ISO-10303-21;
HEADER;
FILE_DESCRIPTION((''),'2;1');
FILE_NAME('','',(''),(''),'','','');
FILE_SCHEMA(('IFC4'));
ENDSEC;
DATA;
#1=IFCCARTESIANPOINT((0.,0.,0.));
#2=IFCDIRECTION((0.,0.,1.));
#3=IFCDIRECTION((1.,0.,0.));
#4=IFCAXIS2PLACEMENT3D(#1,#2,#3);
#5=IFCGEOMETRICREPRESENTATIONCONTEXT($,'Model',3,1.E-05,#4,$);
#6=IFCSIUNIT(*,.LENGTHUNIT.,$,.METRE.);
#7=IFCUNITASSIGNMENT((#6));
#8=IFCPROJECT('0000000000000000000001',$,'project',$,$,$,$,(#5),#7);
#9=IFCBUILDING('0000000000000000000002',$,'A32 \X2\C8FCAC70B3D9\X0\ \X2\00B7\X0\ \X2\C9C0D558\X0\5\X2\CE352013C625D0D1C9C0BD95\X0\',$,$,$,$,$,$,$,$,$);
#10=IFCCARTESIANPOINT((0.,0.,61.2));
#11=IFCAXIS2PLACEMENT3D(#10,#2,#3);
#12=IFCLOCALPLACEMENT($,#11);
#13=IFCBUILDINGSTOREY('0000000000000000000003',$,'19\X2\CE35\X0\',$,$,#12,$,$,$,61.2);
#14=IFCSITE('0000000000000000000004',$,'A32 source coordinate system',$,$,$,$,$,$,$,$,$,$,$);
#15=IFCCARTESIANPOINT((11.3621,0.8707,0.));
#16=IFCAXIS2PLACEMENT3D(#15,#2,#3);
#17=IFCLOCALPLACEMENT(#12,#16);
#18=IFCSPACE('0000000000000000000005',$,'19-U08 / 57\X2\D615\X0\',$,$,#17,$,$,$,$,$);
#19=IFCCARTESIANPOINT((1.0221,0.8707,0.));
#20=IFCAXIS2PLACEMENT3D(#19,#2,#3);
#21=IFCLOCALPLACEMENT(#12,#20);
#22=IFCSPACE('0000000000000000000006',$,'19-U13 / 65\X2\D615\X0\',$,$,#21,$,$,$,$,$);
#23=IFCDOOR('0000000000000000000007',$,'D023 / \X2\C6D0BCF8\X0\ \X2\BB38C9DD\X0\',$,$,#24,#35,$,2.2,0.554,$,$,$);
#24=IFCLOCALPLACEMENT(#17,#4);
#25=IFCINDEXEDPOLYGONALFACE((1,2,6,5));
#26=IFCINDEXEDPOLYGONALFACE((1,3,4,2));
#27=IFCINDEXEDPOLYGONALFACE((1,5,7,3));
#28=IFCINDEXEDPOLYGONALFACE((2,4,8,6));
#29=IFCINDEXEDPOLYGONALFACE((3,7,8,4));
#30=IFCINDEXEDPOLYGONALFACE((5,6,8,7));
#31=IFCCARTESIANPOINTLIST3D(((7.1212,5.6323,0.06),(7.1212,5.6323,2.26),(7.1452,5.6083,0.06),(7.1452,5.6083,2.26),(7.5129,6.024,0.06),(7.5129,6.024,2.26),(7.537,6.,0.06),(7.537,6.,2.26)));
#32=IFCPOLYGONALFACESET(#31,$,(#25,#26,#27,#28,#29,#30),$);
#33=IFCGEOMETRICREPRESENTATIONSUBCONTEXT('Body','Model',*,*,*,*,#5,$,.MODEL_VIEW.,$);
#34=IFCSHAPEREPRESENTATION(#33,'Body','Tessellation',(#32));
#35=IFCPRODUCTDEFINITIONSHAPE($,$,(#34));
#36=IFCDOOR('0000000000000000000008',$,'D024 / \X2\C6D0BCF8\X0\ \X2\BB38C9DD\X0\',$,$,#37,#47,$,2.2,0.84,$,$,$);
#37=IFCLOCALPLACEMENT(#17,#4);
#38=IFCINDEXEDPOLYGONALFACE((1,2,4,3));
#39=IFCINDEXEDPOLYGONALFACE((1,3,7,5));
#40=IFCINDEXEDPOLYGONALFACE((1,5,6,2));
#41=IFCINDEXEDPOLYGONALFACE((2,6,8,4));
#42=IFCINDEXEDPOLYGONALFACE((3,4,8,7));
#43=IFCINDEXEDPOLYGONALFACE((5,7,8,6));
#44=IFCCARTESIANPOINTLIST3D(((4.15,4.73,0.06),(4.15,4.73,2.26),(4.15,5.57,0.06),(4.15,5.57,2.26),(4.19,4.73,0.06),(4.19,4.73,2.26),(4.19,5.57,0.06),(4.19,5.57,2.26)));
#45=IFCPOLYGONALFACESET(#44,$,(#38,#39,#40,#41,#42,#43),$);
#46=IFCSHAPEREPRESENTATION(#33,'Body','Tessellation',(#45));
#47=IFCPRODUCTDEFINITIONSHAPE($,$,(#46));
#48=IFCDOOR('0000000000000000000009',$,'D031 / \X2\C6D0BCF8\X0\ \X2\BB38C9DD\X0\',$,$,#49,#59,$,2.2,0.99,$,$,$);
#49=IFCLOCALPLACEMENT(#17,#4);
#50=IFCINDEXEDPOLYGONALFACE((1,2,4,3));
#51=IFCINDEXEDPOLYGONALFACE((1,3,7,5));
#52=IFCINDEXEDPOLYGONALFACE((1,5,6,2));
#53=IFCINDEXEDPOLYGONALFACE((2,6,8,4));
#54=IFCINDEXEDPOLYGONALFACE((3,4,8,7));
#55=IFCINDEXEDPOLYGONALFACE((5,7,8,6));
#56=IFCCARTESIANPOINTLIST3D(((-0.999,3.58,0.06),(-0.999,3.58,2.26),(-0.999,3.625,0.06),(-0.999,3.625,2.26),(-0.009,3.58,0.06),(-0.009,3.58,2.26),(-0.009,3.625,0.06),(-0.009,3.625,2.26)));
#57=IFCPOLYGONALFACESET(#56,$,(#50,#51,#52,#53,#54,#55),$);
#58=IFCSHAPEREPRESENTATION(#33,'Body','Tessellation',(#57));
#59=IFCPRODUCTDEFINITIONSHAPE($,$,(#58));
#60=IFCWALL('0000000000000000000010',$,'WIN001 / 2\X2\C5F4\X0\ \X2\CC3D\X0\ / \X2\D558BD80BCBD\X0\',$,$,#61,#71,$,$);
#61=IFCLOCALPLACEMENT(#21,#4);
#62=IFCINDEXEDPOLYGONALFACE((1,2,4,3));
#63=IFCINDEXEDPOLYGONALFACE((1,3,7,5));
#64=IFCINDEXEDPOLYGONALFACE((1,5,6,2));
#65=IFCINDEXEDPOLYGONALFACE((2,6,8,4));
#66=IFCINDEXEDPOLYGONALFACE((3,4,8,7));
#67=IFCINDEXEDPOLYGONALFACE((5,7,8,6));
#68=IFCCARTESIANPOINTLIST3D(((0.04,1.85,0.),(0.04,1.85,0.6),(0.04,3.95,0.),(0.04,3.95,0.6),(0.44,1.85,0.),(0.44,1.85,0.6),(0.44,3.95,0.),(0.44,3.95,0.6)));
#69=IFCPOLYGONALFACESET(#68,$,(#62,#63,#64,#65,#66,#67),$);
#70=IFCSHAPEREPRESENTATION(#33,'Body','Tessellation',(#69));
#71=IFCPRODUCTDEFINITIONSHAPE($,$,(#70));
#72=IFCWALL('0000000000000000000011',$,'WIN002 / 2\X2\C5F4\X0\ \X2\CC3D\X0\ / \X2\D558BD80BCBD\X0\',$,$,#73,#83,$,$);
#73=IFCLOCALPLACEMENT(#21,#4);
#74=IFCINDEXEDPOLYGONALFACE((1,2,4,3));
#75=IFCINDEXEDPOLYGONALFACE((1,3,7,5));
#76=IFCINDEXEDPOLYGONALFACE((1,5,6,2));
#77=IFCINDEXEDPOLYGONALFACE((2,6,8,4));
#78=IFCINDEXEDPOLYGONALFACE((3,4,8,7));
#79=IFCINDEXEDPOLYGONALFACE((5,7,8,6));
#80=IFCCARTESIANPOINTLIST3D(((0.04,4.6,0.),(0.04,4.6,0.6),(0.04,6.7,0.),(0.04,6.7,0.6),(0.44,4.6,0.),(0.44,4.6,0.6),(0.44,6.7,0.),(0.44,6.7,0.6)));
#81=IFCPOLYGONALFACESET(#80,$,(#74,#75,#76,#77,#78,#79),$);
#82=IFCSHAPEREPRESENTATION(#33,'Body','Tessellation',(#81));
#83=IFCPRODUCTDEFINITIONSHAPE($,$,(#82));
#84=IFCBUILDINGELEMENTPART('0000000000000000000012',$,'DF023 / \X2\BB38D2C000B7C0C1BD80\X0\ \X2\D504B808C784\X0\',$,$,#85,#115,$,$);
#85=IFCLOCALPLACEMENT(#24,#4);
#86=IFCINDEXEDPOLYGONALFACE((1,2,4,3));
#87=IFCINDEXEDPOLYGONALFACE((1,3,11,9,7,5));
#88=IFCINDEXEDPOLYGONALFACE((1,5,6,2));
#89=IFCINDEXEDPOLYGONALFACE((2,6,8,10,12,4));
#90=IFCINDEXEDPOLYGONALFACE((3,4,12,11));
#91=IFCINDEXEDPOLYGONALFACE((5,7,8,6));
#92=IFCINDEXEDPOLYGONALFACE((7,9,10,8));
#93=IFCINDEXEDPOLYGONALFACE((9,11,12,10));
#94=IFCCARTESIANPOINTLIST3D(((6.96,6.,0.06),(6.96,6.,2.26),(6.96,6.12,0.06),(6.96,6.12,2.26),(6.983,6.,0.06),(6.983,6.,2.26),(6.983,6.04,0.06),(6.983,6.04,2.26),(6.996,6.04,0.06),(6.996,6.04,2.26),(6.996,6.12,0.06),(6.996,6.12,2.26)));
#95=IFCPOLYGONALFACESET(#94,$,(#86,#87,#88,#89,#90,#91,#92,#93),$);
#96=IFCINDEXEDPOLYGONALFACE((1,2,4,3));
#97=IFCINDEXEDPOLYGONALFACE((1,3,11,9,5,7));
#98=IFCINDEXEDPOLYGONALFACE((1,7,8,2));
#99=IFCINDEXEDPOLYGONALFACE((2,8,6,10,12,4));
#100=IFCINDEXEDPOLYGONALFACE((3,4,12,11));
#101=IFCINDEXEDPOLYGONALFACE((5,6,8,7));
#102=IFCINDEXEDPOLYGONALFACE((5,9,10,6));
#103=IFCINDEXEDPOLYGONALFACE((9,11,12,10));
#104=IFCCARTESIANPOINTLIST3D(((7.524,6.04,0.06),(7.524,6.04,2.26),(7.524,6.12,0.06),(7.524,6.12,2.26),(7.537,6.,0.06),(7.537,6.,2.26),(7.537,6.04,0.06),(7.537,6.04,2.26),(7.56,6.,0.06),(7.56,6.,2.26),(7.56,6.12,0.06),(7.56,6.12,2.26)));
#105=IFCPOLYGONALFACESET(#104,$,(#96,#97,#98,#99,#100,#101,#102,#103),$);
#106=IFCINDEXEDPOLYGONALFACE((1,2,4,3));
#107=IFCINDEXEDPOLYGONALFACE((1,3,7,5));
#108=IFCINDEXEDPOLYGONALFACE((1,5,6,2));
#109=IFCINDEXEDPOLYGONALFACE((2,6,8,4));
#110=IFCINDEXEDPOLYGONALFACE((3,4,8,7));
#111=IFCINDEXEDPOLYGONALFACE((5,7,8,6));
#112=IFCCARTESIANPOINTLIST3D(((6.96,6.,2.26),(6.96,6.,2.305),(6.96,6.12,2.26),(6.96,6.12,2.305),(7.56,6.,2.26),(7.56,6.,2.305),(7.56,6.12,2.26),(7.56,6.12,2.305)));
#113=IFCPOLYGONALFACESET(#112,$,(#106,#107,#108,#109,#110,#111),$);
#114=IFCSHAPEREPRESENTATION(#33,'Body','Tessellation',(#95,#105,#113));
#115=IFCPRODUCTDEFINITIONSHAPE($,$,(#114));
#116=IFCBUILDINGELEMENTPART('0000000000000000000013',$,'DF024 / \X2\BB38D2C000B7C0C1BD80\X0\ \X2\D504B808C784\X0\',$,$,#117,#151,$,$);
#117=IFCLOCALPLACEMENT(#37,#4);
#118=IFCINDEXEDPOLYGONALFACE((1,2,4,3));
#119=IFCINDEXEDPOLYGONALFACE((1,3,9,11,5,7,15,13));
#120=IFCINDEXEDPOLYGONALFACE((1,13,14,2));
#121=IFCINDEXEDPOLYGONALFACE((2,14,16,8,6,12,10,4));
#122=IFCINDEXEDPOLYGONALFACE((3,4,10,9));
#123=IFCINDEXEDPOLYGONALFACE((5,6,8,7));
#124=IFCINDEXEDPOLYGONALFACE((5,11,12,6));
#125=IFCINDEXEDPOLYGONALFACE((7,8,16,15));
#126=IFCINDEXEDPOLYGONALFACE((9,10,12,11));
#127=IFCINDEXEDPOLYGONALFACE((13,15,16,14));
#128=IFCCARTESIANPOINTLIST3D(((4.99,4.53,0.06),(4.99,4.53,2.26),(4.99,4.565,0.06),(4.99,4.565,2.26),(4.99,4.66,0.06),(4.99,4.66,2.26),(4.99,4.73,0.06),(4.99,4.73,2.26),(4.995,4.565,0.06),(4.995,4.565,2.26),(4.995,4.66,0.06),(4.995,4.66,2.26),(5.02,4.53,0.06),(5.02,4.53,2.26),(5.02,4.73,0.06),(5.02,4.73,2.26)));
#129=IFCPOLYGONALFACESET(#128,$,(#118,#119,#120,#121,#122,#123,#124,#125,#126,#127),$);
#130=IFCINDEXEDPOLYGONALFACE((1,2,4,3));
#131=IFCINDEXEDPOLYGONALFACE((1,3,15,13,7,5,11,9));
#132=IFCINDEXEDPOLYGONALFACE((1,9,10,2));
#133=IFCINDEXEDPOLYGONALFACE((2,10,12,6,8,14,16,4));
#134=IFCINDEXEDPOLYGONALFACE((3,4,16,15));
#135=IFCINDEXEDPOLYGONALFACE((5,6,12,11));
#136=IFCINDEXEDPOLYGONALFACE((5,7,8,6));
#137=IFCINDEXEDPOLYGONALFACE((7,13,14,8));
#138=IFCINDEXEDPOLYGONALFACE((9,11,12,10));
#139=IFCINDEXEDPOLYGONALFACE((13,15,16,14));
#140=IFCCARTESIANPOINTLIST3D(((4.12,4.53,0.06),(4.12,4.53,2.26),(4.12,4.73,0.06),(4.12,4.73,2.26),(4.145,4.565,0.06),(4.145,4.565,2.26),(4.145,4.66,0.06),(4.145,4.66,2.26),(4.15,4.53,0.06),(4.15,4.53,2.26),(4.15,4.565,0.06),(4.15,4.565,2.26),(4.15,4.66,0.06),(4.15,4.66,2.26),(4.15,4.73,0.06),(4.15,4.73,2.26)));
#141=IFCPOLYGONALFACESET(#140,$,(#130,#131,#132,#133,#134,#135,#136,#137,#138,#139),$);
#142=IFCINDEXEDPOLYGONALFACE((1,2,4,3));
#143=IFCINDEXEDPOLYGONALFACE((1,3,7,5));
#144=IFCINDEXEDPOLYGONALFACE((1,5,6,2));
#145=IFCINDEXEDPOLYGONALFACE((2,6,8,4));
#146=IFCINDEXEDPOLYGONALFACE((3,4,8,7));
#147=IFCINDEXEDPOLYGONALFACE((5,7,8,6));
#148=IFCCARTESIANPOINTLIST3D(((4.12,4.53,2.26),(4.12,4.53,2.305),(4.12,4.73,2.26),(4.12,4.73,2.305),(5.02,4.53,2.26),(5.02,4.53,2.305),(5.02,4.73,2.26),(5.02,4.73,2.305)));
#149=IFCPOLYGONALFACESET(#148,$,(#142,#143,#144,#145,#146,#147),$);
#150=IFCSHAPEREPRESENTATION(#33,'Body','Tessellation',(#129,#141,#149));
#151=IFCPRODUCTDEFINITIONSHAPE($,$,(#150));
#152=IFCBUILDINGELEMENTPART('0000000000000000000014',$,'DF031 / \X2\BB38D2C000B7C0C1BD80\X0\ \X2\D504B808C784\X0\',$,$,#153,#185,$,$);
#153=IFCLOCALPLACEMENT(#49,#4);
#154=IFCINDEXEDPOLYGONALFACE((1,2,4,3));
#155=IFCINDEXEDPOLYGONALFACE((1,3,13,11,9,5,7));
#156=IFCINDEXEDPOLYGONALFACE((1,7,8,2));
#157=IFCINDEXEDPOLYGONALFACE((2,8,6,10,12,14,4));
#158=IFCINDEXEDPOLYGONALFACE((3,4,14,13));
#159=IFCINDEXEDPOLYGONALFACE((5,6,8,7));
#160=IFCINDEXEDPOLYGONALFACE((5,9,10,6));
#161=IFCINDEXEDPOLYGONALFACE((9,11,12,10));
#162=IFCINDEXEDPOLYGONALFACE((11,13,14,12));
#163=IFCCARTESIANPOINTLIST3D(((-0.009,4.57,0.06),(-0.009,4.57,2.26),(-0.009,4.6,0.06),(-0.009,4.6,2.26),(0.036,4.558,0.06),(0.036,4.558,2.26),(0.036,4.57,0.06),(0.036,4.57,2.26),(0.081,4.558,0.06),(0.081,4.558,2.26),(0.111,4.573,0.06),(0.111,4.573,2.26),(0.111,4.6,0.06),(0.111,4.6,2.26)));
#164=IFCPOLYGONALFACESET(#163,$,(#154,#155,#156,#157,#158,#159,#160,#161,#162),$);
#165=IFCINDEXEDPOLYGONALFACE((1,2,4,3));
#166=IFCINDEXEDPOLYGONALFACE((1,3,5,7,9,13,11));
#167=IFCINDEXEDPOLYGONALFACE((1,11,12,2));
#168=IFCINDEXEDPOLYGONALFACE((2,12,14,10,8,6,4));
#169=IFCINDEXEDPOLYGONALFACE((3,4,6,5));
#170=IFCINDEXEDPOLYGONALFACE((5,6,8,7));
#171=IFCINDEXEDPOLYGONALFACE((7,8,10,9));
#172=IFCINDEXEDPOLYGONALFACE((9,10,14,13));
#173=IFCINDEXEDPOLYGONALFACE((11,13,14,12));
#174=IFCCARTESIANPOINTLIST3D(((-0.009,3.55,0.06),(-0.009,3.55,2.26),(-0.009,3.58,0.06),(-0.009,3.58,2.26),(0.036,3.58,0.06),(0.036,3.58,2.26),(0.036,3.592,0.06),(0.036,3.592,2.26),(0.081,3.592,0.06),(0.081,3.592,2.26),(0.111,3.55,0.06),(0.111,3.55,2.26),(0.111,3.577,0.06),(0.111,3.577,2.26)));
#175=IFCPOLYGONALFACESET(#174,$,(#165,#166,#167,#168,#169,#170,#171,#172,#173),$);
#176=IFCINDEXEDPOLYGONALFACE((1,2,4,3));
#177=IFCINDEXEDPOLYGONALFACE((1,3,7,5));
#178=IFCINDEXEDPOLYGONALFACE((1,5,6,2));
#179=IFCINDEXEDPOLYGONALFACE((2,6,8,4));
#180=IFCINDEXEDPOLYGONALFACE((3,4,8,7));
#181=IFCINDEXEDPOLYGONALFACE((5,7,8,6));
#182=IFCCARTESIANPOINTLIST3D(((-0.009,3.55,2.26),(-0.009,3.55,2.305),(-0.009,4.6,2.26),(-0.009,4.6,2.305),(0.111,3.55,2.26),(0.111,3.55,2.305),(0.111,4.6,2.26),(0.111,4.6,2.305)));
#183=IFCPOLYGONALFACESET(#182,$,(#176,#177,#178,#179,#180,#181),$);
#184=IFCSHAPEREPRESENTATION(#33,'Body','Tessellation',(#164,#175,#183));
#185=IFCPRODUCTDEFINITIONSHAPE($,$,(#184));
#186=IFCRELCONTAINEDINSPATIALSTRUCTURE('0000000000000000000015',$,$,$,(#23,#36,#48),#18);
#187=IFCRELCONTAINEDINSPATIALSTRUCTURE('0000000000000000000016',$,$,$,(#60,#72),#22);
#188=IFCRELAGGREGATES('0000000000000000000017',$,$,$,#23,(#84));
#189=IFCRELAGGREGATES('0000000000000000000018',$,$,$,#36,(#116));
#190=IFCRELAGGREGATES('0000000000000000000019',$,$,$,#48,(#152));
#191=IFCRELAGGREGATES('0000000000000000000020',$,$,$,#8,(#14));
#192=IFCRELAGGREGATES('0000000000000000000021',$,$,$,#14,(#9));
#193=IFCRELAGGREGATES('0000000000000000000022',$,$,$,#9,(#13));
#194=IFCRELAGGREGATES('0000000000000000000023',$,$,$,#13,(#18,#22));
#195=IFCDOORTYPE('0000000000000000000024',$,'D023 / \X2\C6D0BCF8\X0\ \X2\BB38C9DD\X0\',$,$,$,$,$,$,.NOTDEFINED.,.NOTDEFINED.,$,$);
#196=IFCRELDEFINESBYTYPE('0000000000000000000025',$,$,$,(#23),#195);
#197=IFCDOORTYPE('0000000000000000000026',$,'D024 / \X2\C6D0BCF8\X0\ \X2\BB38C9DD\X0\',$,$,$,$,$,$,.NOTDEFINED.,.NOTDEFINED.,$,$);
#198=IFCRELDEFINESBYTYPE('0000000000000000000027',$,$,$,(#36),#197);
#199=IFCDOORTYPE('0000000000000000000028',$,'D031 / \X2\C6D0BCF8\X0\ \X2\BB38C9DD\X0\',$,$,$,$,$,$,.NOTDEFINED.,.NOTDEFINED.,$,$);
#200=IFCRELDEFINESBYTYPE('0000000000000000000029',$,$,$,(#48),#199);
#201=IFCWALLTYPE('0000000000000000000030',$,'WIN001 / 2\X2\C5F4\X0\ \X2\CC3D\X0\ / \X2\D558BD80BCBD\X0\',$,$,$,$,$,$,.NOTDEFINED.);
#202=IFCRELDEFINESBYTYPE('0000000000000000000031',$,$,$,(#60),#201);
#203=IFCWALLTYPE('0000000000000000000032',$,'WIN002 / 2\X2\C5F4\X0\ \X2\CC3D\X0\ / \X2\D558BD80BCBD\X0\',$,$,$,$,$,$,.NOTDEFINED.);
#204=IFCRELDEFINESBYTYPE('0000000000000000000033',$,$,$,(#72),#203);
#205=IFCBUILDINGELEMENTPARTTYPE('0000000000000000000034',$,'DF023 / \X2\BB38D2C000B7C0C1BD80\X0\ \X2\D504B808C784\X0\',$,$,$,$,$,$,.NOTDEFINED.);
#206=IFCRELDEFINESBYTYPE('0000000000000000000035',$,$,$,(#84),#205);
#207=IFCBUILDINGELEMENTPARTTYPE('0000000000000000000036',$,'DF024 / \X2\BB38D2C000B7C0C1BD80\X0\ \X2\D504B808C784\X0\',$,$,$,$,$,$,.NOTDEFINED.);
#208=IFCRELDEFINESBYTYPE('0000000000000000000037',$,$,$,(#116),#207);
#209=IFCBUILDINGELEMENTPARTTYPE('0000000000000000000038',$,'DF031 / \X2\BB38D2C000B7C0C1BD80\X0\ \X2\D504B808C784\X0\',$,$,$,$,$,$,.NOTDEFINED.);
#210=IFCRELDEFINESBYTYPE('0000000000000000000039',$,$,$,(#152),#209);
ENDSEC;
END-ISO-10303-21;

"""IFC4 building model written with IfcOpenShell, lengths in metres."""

from ifc_helpers import new_model, si_unit, frame, origin, origin_with_axes, place, context, subcontext, project, spatial, polyline, outline, extrude, source, transform, mapped, type_object, type_shapes, element, aggregate, save


model = new_model("IFC4")

# Units and contexts
model_context = context("Model", 3, precision=1e-05, world=origin_with_axes())
body_context = subcontext(model_context, "Body", "Model", "MODEL_VIEW")
ifc_project = project(units=[si_unit("LENGTHUNIT", "METRE")], contexts=[model_context])

# Site, building, storey, space
site = spatial("IfcSite", under=ifc_project, Name="A32 source coordinate system")
building = spatial("IfcBuilding", under=site, Name="A32 주거동 · 지하5층–옥탑지붕")
storey_placement = place(None, frame((0.0, 0.0, 61.2), z_axis=(0.0, 0.0, 1.0), x_axis=(1.0, 0.0, 0.0)))
storey = spatial("IfcBuildingStorey", under=building, at=storey_placement, Name="19층", Elevation=61.2)
space_1_placement = place(storey_placement, frame((11.3621, 0.8707, 0.0), z_axis=(0.0, 0.0, 1.0), x_axis=(1.0, 0.0, 0.0)))
space_1 = spatial("IfcSpace", under=storey, at=space_1_placement, Name="19-U08 / 57형")

# Doors
door_type_1 = type_object("IfcDoorType", Name="D023 / 원본 문짝", OperationType="NOTDEFINED", PredefinedType="NOTDEFINED")
shared_shape_1 = source(origin(), body_context, "Body", "SweptSolid", [
    extrude(outline(polyline([(7.537, 6.0), (7.1452, 5.6083), (7.1212, 5.6323), (7.5129, 6.024), (7.537, 6.0)])), frame((0.0, 0.0, 0.06)), (0.0, 0.0, 1.0), 2.2),
])
type_shapes(door_type_1, [shared_shape_1])
door_1_placement = place(space_1_placement, origin_with_axes())
door_1 = element("IfcDoor", 1, at=door_1_placement, inside=space_1, type_object=door_type_1, Name="D023 / 원본 문짝", OverallHeight=2.2, OverallWidth=0.554, context=body_context, shape_type="MappedRepresentation", body=[
    mapped(shared_shape_1, transform((0.0, 0.0, 0.0), scale=1.0)),
])
door_type_2 = type_object("IfcDoorType", Name="D024 / 원본 문짝", OperationType="NOTDEFINED", PredefinedType="NOTDEFINED")
shared_shape_2 = source(origin(), body_context, "Body", "SweptSolid", [
    extrude(outline(polyline([(4.15, 4.73), (4.15, 5.57), (4.19, 5.57), (4.19, 4.73), (4.15, 4.73)])), frame((0.0, 0.0, 0.06)), (0.0, 0.0, 1.0), 2.2),
])
type_shapes(door_type_2, [shared_shape_2])
door_2_placement = place(space_1_placement, origin_with_axes())
door_2 = element("IfcDoor", 2, at=door_2_placement, inside=space_1, type_object=door_type_2, Name="D024 / 원본 문짝", OverallHeight=2.2, OverallWidth=0.84, context=body_context, shape_type="MappedRepresentation", body=[
    mapped(shared_shape_2, transform((0.0, 0.0, 0.0), scale=1.0)),
])
door_type_3 = type_object("IfcDoorType", Name="D031 / 원본 문짝", OperationType="NOTDEFINED", PredefinedType="NOTDEFINED")
shared_shape_3 = source(origin(), body_context, "Body", "SweptSolid", [
    extrude(outline(polyline([(-0.009, 3.58), (-0.999, 3.58), (-0.999, 3.625), (-0.009, 3.625), (-0.009, 3.58)])), frame((0.0, 0.0, 0.06)), (0.0, 0.0, 1.0), 2.2),
])
type_shapes(door_type_3, [shared_shape_3])
door_3_placement = place(space_1_placement, origin_with_axes())
door_3 = element("IfcDoor", 3, at=door_3_placement, inside=space_1, type_object=door_type_3, Name="D031 / 원본 문짝", OverallHeight=2.2, OverallWidth=0.99, context=body_context, shape_type="MappedRepresentation", body=[
    mapped(shared_shape_3, transform((0.0, 0.0, 0.0), scale=1.0)),
])

# Shared definitions
space_2_placement = place(storey_placement, frame((1.0221, 0.8707, 0.0), z_axis=(0.0, 0.0, 1.0), x_axis=(1.0, 0.0, 0.0)))
space_2 = spatial("IfcSpace", under=storey, at=space_2_placement, Name="19-U13 / 65형")

# Walls
wall_type_1 = type_object("IfcWallType", Name="WIN001 / 2열 창 / 하부벽", PredefinedType="NOTDEFINED")
shared_shape_4 = source(origin(), body_context, "Body", "SweptSolid", [
    extrude(outline(polyline([(0.04, 3.95), (0.44, 3.95), (0.44, 1.85), (0.04, 1.85), (0.04, 3.95)])), origin(), (0.0, 0.0, 1.0), 0.6),
])
type_shapes(wall_type_1, [shared_shape_4])
wall_1_placement = place(space_2_placement, origin_with_axes())
element("IfcWall", 4, at=wall_1_placement, inside=space_2, type_object=wall_type_1, Name="WIN001 / 2열 창 / 하부벽", context=body_context, shape_type="MappedRepresentation", body=[
    mapped(shared_shape_4, transform((0.0, 0.0, 0.0), scale=1.0)),
])
wall_type_2 = type_object("IfcWallType", Name="WIN002 / 2열 창 / 하부벽", PredefinedType="NOTDEFINED")
shared_shape_5 = source(origin(), body_context, "Body", "SweptSolid", [
    extrude(outline(polyline([(0.04, 6.7), (0.44, 6.7), (0.44, 4.6), (0.04, 4.6), (0.04, 6.7)])), origin(), (0.0, 0.0, 1.0), 0.6),
])
type_shapes(wall_type_2, [shared_shape_5])
wall_2_placement = place(space_2_placement, origin_with_axes())
element("IfcWall", 5, at=wall_2_placement, inside=space_2, type_object=wall_type_2, Name="WIN002 / 2열 창 / 하부벽", context=body_context, shape_type="MappedRepresentation", body=[
    mapped(shared_shape_5, transform((0.0, 0.0, 0.0), scale=1.0)),
])

# Building element parts
building_element_part_type_1 = type_object("IfcBuildingElementPartType", Name="DF023 / 문틀·상부 프레임", PredefinedType="NOTDEFINED")
shared_shape_6 = source(origin(), body_context, "Body", "SweptSolid", [
    extrude(outline(polyline([(6.996, 6.12), (6.996, 6.04), (6.983, 6.04), (6.983, 6.0), (6.96, 6.0), (6.96, 6.12), (6.996, 6.12)])), frame((0.0, 0.0, 0.06)), (0.0, 0.0, 1.0), 2.2),
    extrude(outline(polyline([(7.56, 6.0), (7.537, 6.0), (7.537, 6.04), (7.524, 6.04), (7.524, 6.12), (7.56, 6.12), (7.56, 6.0)])), frame((0.0, 0.0, 0.06)), (0.0, 0.0, 1.0), 2.2),
    extrude(outline(polyline([(6.96, 6.0), (6.96, 6.12), (7.56, 6.12), (7.56, 6.0), (6.96, 6.0)])), frame((0.0, 0.0, 2.26)), (0.0, 0.0, 1.0), 0.045),
])
type_shapes(building_element_part_type_1, [shared_shape_6])
building_element_part_1_placement = place(door_1_placement, origin_with_axes())
building_element_part_1 = element("IfcBuildingElementPart", 6, at=building_element_part_1_placement, type_object=building_element_part_type_1, Name="DF023 / 문틀·상부 프레임", context=body_context, shape_type="MappedRepresentation", body=[
    mapped(shared_shape_6, transform((0.0, 0.0, 0.0), scale=1.0)),
])
aggregate(door_1, [building_element_part_1])
building_element_part_type_2 = type_object("IfcBuildingElementPartType", Name="DF024 / 문틀·상부 프레임", PredefinedType="NOTDEFINED")
shared_shape_7 = source(origin(), body_context, "Body", "SweptSolid", [
    extrude(outline(polyline([(5.02, 4.53), (4.99, 4.53), (4.99, 4.565), (4.995, 4.565), (4.995, 4.66), (4.99, 4.66), (4.99, 4.73), (5.02, 4.73), (5.02, 4.53)])), frame((0.0, 0.0, 0.06)), (0.0, 0.0, 1.0), 2.2),
    extrude(outline(polyline([(4.15, 4.73), (4.15, 4.66), (4.145, 4.66), (4.145, 4.565), (4.15, 4.565), (4.15, 4.53), (4.12, 4.53), (4.12, 4.73), (4.15, 4.73)])), frame((0.0, 0.0, 0.06)), (0.0, 0.0, 1.0), 2.2),
    extrude(outline(polyline([(4.12, 4.53), (4.12, 4.73), (5.02, 4.73), (5.02, 4.53), (4.12, 4.53)])), frame((0.0, 0.0, 2.26)), (0.0, 0.0, 1.0), 0.045),
])
type_shapes(building_element_part_type_2, [shared_shape_7])
building_element_part_2_placement = place(door_2_placement, origin_with_axes())
building_element_part_2 = element("IfcBuildingElementPart", 7, at=building_element_part_2_placement, type_object=building_element_part_type_2, Name="DF024 / 문틀·상부 프레임", context=body_context, shape_type="MappedRepresentation", body=[
    mapped(shared_shape_7, transform((0.0, 0.0, 0.0), scale=1.0)),
])
aggregate(door_2, [building_element_part_2])
building_element_part_type_3 = type_object("IfcBuildingElementPartType", Name="DF031 / 문틀·상부 프레임", PredefinedType="NOTDEFINED")
shared_shape_8 = source(origin(), body_context, "Body", "SweptSolid", [
    extrude(outline(polyline([(0.111, 4.6), (0.111, 4.573), (0.081, 4.558), (0.036, 4.558), (0.036, 4.57), (-0.009, 4.57), (-0.009, 4.6), (0.111, 4.6)])), frame((0.0, 0.0, 0.06)), (0.0, 0.0, 1.0), 2.2),
    extrude(outline(polyline([(-0.009, 3.58), (0.036, 3.58), (0.036, 3.592), (0.081, 3.592), (0.111, 3.577), (0.111, 3.55), (-0.009, 3.55), (-0.009, 3.58)])), frame((0.0, 0.0, 0.06)), (0.0, 0.0, 1.0), 2.2),
    extrude(outline(polyline([(-0.009, 3.55), (-0.009, 4.6), (0.111, 4.6), (0.111, 3.55), (-0.009, 3.55)])), frame((0.0, 0.0, 2.26)), (0.0, 0.0, 1.0), 0.045),
])
type_shapes(building_element_part_type_3, [shared_shape_8])
building_element_part_3_placement = place(door_3_placement, origin_with_axes())
building_element_part_3 = element("IfcBuildingElementPart", 8, at=building_element_part_3_placement, type_object=building_element_part_type_3, Name="DF031 / 문틀·상부 프레임", context=body_context, shape_type="MappedRepresentation", body=[
    mapped(shared_shape_8, transform((0.0, 0.0, 0.0), scale=1.0)),
])
aggregate(door_3, [building_element_part_3])

save(model, "model.ifc")
